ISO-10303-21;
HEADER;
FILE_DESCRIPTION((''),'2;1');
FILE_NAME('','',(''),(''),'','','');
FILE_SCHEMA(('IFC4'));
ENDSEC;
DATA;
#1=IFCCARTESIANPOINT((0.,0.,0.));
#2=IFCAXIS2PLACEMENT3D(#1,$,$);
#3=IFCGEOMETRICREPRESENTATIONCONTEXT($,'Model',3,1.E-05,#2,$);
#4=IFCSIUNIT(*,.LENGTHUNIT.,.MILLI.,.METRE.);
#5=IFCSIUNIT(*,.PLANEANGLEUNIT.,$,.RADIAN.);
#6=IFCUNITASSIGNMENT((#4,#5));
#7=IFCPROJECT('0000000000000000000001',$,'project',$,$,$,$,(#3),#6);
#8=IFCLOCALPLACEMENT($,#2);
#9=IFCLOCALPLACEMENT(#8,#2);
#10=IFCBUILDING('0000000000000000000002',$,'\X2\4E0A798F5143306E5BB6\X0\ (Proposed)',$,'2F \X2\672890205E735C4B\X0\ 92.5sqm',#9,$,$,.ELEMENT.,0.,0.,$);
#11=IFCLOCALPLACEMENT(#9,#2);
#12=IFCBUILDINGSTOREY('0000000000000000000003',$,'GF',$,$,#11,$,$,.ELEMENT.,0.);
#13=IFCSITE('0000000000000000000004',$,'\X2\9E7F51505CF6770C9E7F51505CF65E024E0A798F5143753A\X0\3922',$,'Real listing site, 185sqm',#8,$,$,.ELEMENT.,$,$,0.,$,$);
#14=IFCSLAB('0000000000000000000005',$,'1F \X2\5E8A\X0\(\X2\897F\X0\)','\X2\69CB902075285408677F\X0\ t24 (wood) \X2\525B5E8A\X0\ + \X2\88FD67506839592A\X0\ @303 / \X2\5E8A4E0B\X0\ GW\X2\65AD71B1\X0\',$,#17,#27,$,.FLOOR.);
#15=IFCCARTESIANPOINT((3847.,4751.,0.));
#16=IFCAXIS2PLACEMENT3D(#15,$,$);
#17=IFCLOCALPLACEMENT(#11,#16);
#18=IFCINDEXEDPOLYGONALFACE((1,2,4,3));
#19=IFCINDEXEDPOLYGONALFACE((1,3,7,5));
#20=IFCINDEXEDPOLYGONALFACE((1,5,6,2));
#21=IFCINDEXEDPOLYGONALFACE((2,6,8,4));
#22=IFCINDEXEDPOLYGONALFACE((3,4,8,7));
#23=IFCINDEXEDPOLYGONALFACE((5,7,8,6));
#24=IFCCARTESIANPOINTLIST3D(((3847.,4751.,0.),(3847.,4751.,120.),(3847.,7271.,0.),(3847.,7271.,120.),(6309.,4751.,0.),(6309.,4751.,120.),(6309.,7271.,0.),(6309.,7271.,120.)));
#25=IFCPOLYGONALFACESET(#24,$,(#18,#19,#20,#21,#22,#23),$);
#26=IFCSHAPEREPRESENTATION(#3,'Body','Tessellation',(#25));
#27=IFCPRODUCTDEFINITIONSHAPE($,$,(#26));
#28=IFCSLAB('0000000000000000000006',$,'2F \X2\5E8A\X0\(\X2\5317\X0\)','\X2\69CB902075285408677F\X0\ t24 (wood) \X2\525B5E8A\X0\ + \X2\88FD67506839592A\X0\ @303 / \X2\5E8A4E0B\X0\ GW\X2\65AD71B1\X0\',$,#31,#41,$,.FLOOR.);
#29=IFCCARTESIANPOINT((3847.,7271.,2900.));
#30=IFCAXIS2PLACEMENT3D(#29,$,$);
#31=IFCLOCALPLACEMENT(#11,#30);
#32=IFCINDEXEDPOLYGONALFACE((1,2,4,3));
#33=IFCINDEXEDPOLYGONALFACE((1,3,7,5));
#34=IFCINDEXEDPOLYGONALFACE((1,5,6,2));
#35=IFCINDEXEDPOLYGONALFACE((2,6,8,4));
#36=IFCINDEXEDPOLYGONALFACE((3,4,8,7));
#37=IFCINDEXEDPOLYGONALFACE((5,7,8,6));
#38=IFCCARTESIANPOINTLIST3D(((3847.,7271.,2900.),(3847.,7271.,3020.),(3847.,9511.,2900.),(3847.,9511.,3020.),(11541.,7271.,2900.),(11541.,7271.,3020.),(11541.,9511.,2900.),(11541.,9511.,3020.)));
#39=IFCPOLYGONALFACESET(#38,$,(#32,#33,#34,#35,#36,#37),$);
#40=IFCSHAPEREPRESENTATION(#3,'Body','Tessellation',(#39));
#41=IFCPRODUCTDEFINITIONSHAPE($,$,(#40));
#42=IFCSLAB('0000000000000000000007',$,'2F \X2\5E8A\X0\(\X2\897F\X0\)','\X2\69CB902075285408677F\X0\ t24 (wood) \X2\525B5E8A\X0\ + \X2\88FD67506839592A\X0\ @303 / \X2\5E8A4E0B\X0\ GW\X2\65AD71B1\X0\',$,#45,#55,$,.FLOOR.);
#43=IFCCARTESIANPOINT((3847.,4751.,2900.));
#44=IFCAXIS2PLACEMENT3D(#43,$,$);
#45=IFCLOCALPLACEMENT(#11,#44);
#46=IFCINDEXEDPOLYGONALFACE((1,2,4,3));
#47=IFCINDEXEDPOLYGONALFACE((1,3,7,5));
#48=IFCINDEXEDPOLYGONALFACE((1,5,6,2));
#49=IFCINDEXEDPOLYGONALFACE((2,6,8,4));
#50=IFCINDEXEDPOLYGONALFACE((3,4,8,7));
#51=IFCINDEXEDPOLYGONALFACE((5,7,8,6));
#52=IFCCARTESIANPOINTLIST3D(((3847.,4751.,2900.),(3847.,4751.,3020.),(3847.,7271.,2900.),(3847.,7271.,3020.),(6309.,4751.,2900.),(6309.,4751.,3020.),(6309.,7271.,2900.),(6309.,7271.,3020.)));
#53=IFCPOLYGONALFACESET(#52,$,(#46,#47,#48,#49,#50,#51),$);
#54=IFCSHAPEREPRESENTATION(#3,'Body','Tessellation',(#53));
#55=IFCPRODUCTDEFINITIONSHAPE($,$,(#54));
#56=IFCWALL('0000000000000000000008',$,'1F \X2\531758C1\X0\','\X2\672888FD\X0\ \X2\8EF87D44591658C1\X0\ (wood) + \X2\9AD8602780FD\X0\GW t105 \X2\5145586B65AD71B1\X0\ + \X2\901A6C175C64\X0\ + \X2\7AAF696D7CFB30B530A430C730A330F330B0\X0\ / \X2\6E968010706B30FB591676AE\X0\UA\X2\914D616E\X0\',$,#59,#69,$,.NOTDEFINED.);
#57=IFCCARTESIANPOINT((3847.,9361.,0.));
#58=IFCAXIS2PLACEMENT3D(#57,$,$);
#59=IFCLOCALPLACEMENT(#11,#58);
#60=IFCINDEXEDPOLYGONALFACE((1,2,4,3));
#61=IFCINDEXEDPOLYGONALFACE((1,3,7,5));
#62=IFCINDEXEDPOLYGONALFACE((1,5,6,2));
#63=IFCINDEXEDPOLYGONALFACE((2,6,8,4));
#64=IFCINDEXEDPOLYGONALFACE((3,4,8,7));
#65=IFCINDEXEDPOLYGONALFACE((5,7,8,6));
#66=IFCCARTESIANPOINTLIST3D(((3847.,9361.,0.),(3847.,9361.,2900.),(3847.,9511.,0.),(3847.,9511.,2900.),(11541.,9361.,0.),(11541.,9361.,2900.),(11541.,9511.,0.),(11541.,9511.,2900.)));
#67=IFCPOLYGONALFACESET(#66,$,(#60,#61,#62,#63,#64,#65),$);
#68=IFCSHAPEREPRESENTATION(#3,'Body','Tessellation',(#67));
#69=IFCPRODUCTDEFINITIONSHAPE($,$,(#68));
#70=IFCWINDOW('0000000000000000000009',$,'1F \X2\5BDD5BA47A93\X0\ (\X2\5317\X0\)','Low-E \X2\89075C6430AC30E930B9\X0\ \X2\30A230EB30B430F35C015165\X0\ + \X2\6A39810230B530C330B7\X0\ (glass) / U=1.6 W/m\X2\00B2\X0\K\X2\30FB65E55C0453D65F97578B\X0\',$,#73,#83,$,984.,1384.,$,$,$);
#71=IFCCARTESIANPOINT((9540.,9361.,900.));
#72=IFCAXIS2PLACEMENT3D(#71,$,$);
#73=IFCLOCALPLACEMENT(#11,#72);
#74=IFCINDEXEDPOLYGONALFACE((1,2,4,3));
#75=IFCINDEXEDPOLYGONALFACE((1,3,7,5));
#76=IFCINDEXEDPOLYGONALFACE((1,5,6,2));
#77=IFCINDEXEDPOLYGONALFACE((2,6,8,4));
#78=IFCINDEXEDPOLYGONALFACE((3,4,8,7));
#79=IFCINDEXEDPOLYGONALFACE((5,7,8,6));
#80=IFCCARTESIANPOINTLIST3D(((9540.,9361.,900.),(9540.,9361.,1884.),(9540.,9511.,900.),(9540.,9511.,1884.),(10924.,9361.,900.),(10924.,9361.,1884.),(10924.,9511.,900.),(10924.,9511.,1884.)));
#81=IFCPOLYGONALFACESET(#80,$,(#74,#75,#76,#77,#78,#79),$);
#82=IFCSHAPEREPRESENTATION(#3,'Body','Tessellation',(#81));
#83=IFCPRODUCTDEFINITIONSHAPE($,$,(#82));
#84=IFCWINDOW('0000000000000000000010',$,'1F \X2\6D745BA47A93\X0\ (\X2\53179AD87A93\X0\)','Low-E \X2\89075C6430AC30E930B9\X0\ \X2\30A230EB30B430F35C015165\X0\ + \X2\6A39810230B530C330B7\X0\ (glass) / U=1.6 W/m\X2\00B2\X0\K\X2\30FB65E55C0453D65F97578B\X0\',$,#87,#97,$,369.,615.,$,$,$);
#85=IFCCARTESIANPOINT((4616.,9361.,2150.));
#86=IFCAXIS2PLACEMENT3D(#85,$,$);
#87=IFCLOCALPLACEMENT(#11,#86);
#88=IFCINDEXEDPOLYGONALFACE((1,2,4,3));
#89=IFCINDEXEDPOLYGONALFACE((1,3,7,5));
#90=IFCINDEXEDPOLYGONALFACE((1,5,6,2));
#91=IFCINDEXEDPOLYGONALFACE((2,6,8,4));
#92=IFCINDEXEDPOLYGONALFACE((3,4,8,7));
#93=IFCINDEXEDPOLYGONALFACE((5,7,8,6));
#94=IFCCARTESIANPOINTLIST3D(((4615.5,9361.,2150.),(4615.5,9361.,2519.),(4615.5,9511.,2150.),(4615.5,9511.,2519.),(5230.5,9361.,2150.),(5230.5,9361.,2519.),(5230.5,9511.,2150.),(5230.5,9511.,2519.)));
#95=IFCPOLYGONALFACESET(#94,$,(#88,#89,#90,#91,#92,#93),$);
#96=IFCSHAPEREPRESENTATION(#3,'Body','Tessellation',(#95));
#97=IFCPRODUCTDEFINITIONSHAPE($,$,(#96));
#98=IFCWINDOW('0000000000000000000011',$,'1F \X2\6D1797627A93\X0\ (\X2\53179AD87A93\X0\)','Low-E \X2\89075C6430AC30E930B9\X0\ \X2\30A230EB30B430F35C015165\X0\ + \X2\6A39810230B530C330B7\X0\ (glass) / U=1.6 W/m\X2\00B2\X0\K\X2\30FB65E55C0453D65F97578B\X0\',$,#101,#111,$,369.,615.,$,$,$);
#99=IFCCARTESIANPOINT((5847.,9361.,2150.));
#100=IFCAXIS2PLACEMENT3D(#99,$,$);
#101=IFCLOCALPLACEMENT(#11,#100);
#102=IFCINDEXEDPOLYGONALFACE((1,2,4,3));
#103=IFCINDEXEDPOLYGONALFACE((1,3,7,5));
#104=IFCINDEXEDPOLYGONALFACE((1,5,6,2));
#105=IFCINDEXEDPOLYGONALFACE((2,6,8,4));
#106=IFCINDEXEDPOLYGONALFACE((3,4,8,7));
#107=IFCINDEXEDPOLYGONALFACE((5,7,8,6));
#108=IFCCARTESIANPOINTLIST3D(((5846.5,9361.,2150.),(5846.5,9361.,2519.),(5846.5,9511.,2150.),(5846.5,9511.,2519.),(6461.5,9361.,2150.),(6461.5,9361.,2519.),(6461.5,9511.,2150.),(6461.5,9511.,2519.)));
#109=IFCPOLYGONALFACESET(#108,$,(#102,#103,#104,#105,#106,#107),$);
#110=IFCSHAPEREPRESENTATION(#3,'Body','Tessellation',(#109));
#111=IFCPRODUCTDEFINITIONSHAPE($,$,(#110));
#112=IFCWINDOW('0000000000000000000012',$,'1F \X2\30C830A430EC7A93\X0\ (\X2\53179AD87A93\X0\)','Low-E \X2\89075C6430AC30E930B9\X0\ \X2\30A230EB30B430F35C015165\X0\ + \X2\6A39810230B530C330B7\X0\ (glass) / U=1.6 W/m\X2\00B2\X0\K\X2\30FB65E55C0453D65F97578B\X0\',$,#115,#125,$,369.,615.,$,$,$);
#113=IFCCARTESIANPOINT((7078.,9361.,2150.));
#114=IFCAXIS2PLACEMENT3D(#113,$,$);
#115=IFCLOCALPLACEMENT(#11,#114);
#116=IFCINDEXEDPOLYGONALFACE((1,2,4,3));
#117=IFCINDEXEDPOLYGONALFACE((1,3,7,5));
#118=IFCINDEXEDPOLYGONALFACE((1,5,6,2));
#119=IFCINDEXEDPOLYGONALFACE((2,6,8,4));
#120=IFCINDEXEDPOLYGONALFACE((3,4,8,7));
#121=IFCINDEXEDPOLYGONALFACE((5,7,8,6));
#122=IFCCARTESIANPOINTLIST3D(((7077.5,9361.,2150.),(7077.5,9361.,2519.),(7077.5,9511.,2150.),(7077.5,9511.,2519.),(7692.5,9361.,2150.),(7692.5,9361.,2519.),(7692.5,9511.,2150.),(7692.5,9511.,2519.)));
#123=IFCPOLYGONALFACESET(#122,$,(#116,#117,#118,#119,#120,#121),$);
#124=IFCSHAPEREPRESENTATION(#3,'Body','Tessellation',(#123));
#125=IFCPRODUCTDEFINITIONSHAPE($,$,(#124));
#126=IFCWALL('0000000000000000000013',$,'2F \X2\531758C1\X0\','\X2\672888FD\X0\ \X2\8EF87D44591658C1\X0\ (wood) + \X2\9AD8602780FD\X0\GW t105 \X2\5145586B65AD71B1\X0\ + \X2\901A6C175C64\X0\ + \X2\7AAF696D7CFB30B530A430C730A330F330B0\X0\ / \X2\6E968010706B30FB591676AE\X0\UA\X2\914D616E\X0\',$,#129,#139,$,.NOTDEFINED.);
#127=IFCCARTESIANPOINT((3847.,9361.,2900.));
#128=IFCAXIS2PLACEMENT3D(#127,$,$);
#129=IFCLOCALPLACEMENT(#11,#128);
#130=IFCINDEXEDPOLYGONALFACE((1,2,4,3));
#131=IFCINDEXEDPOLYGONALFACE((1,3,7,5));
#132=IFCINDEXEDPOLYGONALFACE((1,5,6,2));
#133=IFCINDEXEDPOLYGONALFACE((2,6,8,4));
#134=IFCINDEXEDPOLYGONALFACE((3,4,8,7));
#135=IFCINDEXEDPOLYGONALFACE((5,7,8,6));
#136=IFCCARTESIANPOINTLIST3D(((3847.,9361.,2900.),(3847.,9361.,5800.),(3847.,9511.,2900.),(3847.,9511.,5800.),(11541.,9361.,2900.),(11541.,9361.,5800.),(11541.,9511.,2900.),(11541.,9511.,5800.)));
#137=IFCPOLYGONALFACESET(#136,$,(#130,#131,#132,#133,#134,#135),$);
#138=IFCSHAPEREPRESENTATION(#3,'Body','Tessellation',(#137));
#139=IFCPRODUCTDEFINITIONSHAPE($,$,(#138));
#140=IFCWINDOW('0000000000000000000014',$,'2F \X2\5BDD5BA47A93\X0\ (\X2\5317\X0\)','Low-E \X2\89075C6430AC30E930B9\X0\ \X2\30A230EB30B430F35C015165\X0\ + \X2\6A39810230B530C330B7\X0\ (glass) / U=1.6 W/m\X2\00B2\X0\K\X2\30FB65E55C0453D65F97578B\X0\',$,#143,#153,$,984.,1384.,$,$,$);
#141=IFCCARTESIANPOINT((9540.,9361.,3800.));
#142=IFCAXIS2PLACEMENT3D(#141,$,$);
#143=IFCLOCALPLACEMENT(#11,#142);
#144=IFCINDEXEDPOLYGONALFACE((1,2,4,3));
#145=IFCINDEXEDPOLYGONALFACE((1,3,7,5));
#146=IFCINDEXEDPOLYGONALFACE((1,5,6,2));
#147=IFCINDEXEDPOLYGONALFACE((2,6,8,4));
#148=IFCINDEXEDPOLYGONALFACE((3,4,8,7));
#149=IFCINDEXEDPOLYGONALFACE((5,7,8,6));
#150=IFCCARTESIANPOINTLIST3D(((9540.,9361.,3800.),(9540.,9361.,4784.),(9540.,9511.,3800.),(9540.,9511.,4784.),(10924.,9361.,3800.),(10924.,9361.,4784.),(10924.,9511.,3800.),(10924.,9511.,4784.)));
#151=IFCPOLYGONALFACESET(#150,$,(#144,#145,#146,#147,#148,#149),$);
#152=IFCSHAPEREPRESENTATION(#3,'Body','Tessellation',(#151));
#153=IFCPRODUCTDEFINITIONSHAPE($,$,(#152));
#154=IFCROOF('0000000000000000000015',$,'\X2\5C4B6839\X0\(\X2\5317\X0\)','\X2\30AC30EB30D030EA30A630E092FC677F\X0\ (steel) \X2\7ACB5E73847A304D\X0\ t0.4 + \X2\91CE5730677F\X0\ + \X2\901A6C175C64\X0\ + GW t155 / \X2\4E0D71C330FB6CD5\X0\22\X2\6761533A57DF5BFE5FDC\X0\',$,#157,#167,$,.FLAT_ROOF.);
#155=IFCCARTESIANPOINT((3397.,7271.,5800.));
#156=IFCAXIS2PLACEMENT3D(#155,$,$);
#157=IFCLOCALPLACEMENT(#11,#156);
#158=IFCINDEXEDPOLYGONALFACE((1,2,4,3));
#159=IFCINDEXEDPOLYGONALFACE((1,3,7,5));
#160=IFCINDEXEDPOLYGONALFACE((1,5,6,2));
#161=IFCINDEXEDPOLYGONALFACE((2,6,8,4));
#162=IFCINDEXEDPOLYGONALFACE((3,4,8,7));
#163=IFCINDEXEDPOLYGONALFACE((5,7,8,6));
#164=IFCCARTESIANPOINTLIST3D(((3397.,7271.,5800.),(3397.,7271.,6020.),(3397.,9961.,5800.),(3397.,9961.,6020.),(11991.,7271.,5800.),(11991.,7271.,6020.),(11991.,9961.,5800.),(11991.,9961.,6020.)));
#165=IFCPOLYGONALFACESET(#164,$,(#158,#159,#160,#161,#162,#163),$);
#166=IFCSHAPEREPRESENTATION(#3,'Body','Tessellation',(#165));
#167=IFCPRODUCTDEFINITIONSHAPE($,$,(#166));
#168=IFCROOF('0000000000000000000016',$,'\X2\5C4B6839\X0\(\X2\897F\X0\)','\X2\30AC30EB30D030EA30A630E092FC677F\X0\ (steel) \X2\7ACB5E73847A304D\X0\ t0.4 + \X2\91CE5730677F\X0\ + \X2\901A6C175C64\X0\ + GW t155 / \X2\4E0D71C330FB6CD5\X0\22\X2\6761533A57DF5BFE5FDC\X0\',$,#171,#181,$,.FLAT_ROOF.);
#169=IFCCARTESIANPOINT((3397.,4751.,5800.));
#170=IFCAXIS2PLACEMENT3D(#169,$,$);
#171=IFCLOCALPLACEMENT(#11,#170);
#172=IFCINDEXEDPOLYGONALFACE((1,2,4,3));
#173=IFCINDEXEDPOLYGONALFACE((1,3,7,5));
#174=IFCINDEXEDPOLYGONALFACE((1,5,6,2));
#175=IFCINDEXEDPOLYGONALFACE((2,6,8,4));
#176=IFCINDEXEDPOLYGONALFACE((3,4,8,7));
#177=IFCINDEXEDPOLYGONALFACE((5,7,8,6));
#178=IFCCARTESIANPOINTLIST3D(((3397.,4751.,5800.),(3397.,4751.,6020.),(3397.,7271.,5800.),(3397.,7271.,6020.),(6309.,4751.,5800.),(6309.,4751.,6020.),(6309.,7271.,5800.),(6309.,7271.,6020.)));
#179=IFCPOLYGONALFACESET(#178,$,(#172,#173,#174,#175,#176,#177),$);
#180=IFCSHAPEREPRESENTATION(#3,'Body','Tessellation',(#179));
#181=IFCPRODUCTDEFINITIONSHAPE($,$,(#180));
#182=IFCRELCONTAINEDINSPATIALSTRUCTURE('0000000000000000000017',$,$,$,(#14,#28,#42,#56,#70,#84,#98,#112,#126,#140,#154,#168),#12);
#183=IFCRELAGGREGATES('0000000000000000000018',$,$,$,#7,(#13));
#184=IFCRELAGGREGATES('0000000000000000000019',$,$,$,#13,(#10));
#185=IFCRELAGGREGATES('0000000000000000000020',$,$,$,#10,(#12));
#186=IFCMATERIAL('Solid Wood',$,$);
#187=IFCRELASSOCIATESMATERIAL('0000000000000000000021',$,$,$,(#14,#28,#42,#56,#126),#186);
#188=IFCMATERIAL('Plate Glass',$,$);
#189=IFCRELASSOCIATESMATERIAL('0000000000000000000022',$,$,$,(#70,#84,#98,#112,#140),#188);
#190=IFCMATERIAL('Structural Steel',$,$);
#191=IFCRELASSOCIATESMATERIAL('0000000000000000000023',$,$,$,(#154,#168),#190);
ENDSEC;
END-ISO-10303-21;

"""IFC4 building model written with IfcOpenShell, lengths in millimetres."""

from ifc_helpers import new_model, si_unit, frame, frame_2d, origin, place, context, project, spatial, rectangle, extrude, material, element, fill, save


model = new_model("IFC4")

# Units and contexts
model_context = context("Model", 3, precision=1e-05, world=origin())
ifc_project = project(units=[si_unit("LENGTHUNIT", "METRE", prefix="MILLI"), si_unit("PLANEANGLEUNIT", "RADIAN")], contexts=[model_context])

# Site, building, storey
site_placement = place(None, origin())
site = spatial("IfcSite", under=ifc_project, at=site_placement, Name="鹿児島県鹿児島市上福元町3922", ObjectType="Real listing site, 185sqm", CompositionType="ELEMENT", RefElevation=0.0)
building_placement = place(site_placement, origin())
building = spatial("IfcBuilding", under=site, at=building_placement, Name="上福元の家 (Proposed)", ObjectType="2F 木造平屋 92.5sqm", CompositionType="ELEMENT", ElevationOfRefHeight=0.0, ElevationOfTerrain=0.0)
storey_placement = place(building_placement, origin())
storey = spatial("IfcBuildingStorey", under=building, at=storey_placement, Name="GF", CompositionType="ELEMENT", Elevation=0.0)

# Slabs
ifc_material_1 = material(Name="Solid Wood")
slab_1_placement = place(storey_placement, frame((3847.0, 4751.0, 0.0)))
element("IfcSlab", 1, at=slab_1_placement, inside=storey, material=ifc_material_1, Name="1F 床(西)", Description="構造用合板 t24 (wood) 剛床 + 製材根太 @303 / 床下 GW断熱", PredefinedType="FLOOR", context=model_context, shape_type="SweptSolid", body=[
    extrude(rectangle(XDim=2462.0, YDim=2520.0, at=frame_2d((1231.0, 1260.0))), frame((3847.0, 4751.0, 0.0)), (0.0, 0.0, 1.0), 120.0),
])
slab_2_placement = place(storey_placement, frame((3847.0, 7271.0, 2900.0)))
element("IfcSlab", 2, at=slab_2_placement, inside=storey, material=ifc_material_1, Name="2F 床(北)", Description="構造用合板 t24 (wood) 剛床 + 製材根太 @303 / 床下 GW断熱", PredefinedType="FLOOR", context=model_context, shape_type="SweptSolid", body=[
    extrude(rectangle(XDim=7694.0, YDim=2240.0, at=frame_2d((3847.0, 1120.0))), frame((3847.0, 7271.0, 2900.0)), (0.0, 0.0, 1.0), 120.0),
])
slab_3_placement = place(storey_placement, frame((3847.0, 4751.0, 2900.0)))
element("IfcSlab", 3, at=slab_3_placement, inside=storey, material=ifc_material_1, Name="2F 床(西)", Description="構造用合板 t24 (wood) 剛床 + 製材根太 @303 / 床下 GW断熱", PredefinedType="FLOOR", context=model_context, shape_type="SweptSolid", body=[
    extrude(rectangle(XDim=2462.0, YDim=2520.0, at=frame_2d((1231.0, 1260.0))), frame((3847.0, 4751.0, 2900.0)), (0.0, 0.0, 1.0), 120.0),
])

# Wall, openings, windows
wall_1_placement = place(storey_placement, frame((3847.0, 9361.0, 0.0)))
wall_1 = element("IfcWall", 4, at=wall_1_placement, inside=storey, material=ifc_material_1, Name="1F 北壁", Description="木製 軸組外壁 (wood) + 高性能GW t105 充填断熱 + 通気層 + 窯業系サイディング / 準耐火・外皮UA配慮", PredefinedType="NOTDEFINED", context=model_context, shape_type="SweptSolid", body=[
    extrude(rectangle(XDim=7694.0, YDim=150.0, at=frame_2d((3847.0, 75.0))), frame((3847.0, 9361.0, 0.0)), (0.0, 0.0, 1.0), 2900.0),
])
opening_1_placement = place(storey_placement, frame((9540.0, 9361.0, 900.0)))
opening_1 = element("IfcOpeningElement", 5, at=opening_1_placement, cuts=wall_1, PredefinedType="NOTDEFINED", context=model_context, shape_type="SweptSolid", body=[
    extrude(rectangle(XDim=1384.0, YDim=150.0, at=frame_2d((692.0, 75.0))), frame((9540.0, 9361.0, 900.0)), (0.0, 0.0, 1.0), 984.0),
])
opening_2_placement = place(storey_placement, frame((4616.0, 9361.0, 2150.0)))
opening_2 = element("IfcOpeningElement", 6, at=opening_2_placement, cuts=wall_1, PredefinedType="NOTDEFINED", context=model_context, shape_type="SweptSolid", body=[
    extrude(rectangle(XDim=615.0, YDim=150.0, at=frame_2d((307.0, 75.0))), frame((4616.0, 9361.0, 2150.0)), (0.0, 0.0, 1.0), 369.0),
])
opening_3_placement = place(storey_placement, frame((5847.0, 9361.0, 2150.0)))
opening_3 = element("IfcOpeningElement", 7, at=opening_3_placement, cuts=wall_1, PredefinedType="NOTDEFINED", context=model_context, shape_type="SweptSolid", body=[
    extrude(rectangle(XDim=615.0, YDim=150.0, at=frame_2d((307.0, 75.0))), frame((5847.0, 9361.0, 2150.0)), (0.0, 0.0, 1.0), 369.0),
])
opening_4_placement = place(storey_placement, frame((7078.0, 9361.0, 2150.0)))
opening_4 = element("IfcOpeningElement", 8, at=opening_4_placement, cuts=wall_1, PredefinedType="NOTDEFINED", context=model_context, shape_type="SweptSolid", body=[
    extrude(rectangle(XDim=615.0, YDim=150.0, at=frame_2d((307.0, 75.0))), frame((7078.0, 9361.0, 2150.0)), (0.0, 0.0, 1.0), 369.0),
])
ifc_material_2 = material(Name="Plate Glass")
window_1_placement = place(storey_placement, frame((9540.0, 9361.0, 900.0)))
window_1 = element("IfcWindow", 9, at=window_1_placement, inside=storey, material=ifc_material_2, Name="1F 寝室窓 (北)", Description="Low-E 複層ガラス アルゴン封入 + 樹脂サッシ (glass) / U=1.6 W/m²K・日射取得型", OverallHeight=984.0, OverallWidth=1384.0, context=model_context, shape_type="SweptSolid", body=[
    extrude(rectangle(XDim=1384.0, YDim=150.0, at=frame_2d((692.0, 75.0))), frame((9540.0, 9361.0, 900.0)), (0.0, 0.0, 1.0), 984.0),
])
fill(opening_1, window_1)
window_2_placement = place(storey_placement, frame((4616.0, 9361.0, 2150.0)))
window_2 = element("IfcWindow", 10, at=window_2_placement, inside=storey, material=ifc_material_2, Name="1F 浴室窓 (北高窓)", Description="Low-E 複層ガラス アルゴン封入 + 樹脂サッシ (glass) / U=1.6 W/m²K・日射取得型", OverallHeight=369.0, OverallWidth=615.0, context=model_context, shape_type="SweptSolid", body=[
    extrude(rectangle(XDim=615.0, YDim=150.0, at=frame_2d((307.0, 75.0))), frame((4616.0, 9361.0, 2150.0)), (0.0, 0.0, 1.0), 369.0),
])
fill(opening_2, window_2)
window_3_placement = place(storey_placement, frame((5847.0, 9361.0, 2150.0)))
window_3 = element("IfcWindow", 11, at=window_3_placement, inside=storey, material=ifc_material_2, Name="1F 洗面窓 (北高窓)", Description="Low-E 複層ガラス アルゴン封入 + 樹脂サッシ (glass) / U=1.6 W/m²K・日射取得型", OverallHeight=369.0, OverallWidth=615.0, context=model_context, shape_type="SweptSolid", body=[
    extrude(rectangle(XDim=615.0, YDim=150.0, at=frame_2d((307.0, 75.0))), frame((5847.0, 9361.0, 2150.0)), (0.0, 0.0, 1.0), 369.0),
])
fill(opening_3, window_3)
window_4_placement = place(storey_placement, frame((7078.0, 9361.0, 2150.0)))
window_4 = element("IfcWindow", 12, at=window_4_placement, inside=storey, material=ifc_material_2, Name="1F トイレ窓 (北高窓)", Description="Low-E 複層ガラス アルゴン封入 + 樹脂サッシ (glass) / U=1.6 W/m²K・日射取得型", OverallHeight=369.0, OverallWidth=615.0, context=model_context, shape_type="SweptSolid", body=[
    extrude(rectangle(XDim=615.0, YDim=150.0, at=frame_2d((307.0, 75.0))), frame((7078.0, 9361.0, 2150.0)), (0.0, 0.0, 1.0), 369.0),
])
fill(opening_4, window_4)

# Wall, opening, window
wall_2_placement = place(storey_placement, frame((3847.0, 9361.0, 2900.0)))
wall_2 = element("IfcWall", 13, at=wall_2_placement, inside=storey, material=ifc_material_1, Name="2F 北壁", Description="木製 軸組外壁 (wood) + 高性能GW t105 充填断熱 + 通気層 + 窯業系サイディング / 準耐火・外皮UA配慮", PredefinedType="NOTDEFINED", context=model_context, shape_type="SweptSolid", body=[
    extrude(rectangle(XDim=7694.0, YDim=150.0, at=frame_2d((3847.0, 75.0))), frame((3847.0, 9361.0, 2900.0)), (0.0, 0.0, 1.0), 2900.0),
])
opening_5_placement = place(storey_placement, frame((9540.0, 9361.0, 3800.0)))
opening_5 = element("IfcOpeningElement", 14, at=opening_5_placement, cuts=wall_2, PredefinedType="NOTDEFINED", context=model_context, shape_type="SweptSolid", body=[
    extrude(rectangle(XDim=1384.0, YDim=150.0, at=frame_2d((692.0, 75.0))), frame((9540.0, 9361.0, 3800.0)), (0.0, 0.0, 1.0), 984.0),
])
window_5_placement = place(storey_placement, frame((9540.0, 9361.0, 3800.0)))
window_5 = element("IfcWindow", 15, at=window_5_placement, inside=storey, material=ifc_material_2, Name="2F 寝室窓 (北)", Description="Low-E 複層ガラス アルゴン封入 + 樹脂サッシ (glass) / U=1.6 W/m²K・日射取得型", OverallHeight=984.0, OverallWidth=1384.0, context=model_context, shape_type="SweptSolid", body=[
    extrude(rectangle(XDim=1384.0, YDim=150.0, at=frame_2d((692.0, 75.0))), frame((9540.0, 9361.0, 3800.0)), (0.0, 0.0, 1.0), 984.0),
])
fill(opening_5, window_5)

# Roofs
ifc_material_3 = material(Name="Structural Steel")
for number, where, name in (
    (16, (3397.0, 7271.0, 5800.0), "屋根(北)"),
):
    element("IfcRoof", number, at=place(storey_placement, frame(where)), inside=storey, material=ifc_material_3, Name=name, Description="ガルバリウム鋼板 (steel) 立平葺き t0.4 + 野地板 + 通気層 + GW t155 / 不燃・法22条区域対応", PredefinedType="FLAT_ROOF", context=model_context, shape_type="SweptSolid", body=[
        extrude(rectangle(XDim=8594.0, YDim=2690.0, at=frame_2d((4297.0, 1345.0))), frame((3397.0, 7271.0, 5800.0)), (0.0, 0.0, 1.0), 220.0),
    ])
roof_placement = place(storey_placement, frame((3397.0, 4751.0, 5800.0)))
element("IfcRoof", 17, at=roof_placement, inside=storey, material=ifc_material_3, Name="屋根(西)", Description="ガルバリウム鋼板 (steel) 立平葺き t0.4 + 野地板 + 通気層 + GW t155 / 不燃・法22条区域対応", PredefinedType="FLAT_ROOF", context=model_context, shape_type="SweptSolid", body=[
    extrude(rectangle(XDim=2912.0, YDim=2520.0, at=frame_2d((1456.0, 1260.0))), frame((3397.0, 4751.0, 5800.0)), (0.0, 0.0, 1.0), 220.0),
])

save(model, "model.ifc")
